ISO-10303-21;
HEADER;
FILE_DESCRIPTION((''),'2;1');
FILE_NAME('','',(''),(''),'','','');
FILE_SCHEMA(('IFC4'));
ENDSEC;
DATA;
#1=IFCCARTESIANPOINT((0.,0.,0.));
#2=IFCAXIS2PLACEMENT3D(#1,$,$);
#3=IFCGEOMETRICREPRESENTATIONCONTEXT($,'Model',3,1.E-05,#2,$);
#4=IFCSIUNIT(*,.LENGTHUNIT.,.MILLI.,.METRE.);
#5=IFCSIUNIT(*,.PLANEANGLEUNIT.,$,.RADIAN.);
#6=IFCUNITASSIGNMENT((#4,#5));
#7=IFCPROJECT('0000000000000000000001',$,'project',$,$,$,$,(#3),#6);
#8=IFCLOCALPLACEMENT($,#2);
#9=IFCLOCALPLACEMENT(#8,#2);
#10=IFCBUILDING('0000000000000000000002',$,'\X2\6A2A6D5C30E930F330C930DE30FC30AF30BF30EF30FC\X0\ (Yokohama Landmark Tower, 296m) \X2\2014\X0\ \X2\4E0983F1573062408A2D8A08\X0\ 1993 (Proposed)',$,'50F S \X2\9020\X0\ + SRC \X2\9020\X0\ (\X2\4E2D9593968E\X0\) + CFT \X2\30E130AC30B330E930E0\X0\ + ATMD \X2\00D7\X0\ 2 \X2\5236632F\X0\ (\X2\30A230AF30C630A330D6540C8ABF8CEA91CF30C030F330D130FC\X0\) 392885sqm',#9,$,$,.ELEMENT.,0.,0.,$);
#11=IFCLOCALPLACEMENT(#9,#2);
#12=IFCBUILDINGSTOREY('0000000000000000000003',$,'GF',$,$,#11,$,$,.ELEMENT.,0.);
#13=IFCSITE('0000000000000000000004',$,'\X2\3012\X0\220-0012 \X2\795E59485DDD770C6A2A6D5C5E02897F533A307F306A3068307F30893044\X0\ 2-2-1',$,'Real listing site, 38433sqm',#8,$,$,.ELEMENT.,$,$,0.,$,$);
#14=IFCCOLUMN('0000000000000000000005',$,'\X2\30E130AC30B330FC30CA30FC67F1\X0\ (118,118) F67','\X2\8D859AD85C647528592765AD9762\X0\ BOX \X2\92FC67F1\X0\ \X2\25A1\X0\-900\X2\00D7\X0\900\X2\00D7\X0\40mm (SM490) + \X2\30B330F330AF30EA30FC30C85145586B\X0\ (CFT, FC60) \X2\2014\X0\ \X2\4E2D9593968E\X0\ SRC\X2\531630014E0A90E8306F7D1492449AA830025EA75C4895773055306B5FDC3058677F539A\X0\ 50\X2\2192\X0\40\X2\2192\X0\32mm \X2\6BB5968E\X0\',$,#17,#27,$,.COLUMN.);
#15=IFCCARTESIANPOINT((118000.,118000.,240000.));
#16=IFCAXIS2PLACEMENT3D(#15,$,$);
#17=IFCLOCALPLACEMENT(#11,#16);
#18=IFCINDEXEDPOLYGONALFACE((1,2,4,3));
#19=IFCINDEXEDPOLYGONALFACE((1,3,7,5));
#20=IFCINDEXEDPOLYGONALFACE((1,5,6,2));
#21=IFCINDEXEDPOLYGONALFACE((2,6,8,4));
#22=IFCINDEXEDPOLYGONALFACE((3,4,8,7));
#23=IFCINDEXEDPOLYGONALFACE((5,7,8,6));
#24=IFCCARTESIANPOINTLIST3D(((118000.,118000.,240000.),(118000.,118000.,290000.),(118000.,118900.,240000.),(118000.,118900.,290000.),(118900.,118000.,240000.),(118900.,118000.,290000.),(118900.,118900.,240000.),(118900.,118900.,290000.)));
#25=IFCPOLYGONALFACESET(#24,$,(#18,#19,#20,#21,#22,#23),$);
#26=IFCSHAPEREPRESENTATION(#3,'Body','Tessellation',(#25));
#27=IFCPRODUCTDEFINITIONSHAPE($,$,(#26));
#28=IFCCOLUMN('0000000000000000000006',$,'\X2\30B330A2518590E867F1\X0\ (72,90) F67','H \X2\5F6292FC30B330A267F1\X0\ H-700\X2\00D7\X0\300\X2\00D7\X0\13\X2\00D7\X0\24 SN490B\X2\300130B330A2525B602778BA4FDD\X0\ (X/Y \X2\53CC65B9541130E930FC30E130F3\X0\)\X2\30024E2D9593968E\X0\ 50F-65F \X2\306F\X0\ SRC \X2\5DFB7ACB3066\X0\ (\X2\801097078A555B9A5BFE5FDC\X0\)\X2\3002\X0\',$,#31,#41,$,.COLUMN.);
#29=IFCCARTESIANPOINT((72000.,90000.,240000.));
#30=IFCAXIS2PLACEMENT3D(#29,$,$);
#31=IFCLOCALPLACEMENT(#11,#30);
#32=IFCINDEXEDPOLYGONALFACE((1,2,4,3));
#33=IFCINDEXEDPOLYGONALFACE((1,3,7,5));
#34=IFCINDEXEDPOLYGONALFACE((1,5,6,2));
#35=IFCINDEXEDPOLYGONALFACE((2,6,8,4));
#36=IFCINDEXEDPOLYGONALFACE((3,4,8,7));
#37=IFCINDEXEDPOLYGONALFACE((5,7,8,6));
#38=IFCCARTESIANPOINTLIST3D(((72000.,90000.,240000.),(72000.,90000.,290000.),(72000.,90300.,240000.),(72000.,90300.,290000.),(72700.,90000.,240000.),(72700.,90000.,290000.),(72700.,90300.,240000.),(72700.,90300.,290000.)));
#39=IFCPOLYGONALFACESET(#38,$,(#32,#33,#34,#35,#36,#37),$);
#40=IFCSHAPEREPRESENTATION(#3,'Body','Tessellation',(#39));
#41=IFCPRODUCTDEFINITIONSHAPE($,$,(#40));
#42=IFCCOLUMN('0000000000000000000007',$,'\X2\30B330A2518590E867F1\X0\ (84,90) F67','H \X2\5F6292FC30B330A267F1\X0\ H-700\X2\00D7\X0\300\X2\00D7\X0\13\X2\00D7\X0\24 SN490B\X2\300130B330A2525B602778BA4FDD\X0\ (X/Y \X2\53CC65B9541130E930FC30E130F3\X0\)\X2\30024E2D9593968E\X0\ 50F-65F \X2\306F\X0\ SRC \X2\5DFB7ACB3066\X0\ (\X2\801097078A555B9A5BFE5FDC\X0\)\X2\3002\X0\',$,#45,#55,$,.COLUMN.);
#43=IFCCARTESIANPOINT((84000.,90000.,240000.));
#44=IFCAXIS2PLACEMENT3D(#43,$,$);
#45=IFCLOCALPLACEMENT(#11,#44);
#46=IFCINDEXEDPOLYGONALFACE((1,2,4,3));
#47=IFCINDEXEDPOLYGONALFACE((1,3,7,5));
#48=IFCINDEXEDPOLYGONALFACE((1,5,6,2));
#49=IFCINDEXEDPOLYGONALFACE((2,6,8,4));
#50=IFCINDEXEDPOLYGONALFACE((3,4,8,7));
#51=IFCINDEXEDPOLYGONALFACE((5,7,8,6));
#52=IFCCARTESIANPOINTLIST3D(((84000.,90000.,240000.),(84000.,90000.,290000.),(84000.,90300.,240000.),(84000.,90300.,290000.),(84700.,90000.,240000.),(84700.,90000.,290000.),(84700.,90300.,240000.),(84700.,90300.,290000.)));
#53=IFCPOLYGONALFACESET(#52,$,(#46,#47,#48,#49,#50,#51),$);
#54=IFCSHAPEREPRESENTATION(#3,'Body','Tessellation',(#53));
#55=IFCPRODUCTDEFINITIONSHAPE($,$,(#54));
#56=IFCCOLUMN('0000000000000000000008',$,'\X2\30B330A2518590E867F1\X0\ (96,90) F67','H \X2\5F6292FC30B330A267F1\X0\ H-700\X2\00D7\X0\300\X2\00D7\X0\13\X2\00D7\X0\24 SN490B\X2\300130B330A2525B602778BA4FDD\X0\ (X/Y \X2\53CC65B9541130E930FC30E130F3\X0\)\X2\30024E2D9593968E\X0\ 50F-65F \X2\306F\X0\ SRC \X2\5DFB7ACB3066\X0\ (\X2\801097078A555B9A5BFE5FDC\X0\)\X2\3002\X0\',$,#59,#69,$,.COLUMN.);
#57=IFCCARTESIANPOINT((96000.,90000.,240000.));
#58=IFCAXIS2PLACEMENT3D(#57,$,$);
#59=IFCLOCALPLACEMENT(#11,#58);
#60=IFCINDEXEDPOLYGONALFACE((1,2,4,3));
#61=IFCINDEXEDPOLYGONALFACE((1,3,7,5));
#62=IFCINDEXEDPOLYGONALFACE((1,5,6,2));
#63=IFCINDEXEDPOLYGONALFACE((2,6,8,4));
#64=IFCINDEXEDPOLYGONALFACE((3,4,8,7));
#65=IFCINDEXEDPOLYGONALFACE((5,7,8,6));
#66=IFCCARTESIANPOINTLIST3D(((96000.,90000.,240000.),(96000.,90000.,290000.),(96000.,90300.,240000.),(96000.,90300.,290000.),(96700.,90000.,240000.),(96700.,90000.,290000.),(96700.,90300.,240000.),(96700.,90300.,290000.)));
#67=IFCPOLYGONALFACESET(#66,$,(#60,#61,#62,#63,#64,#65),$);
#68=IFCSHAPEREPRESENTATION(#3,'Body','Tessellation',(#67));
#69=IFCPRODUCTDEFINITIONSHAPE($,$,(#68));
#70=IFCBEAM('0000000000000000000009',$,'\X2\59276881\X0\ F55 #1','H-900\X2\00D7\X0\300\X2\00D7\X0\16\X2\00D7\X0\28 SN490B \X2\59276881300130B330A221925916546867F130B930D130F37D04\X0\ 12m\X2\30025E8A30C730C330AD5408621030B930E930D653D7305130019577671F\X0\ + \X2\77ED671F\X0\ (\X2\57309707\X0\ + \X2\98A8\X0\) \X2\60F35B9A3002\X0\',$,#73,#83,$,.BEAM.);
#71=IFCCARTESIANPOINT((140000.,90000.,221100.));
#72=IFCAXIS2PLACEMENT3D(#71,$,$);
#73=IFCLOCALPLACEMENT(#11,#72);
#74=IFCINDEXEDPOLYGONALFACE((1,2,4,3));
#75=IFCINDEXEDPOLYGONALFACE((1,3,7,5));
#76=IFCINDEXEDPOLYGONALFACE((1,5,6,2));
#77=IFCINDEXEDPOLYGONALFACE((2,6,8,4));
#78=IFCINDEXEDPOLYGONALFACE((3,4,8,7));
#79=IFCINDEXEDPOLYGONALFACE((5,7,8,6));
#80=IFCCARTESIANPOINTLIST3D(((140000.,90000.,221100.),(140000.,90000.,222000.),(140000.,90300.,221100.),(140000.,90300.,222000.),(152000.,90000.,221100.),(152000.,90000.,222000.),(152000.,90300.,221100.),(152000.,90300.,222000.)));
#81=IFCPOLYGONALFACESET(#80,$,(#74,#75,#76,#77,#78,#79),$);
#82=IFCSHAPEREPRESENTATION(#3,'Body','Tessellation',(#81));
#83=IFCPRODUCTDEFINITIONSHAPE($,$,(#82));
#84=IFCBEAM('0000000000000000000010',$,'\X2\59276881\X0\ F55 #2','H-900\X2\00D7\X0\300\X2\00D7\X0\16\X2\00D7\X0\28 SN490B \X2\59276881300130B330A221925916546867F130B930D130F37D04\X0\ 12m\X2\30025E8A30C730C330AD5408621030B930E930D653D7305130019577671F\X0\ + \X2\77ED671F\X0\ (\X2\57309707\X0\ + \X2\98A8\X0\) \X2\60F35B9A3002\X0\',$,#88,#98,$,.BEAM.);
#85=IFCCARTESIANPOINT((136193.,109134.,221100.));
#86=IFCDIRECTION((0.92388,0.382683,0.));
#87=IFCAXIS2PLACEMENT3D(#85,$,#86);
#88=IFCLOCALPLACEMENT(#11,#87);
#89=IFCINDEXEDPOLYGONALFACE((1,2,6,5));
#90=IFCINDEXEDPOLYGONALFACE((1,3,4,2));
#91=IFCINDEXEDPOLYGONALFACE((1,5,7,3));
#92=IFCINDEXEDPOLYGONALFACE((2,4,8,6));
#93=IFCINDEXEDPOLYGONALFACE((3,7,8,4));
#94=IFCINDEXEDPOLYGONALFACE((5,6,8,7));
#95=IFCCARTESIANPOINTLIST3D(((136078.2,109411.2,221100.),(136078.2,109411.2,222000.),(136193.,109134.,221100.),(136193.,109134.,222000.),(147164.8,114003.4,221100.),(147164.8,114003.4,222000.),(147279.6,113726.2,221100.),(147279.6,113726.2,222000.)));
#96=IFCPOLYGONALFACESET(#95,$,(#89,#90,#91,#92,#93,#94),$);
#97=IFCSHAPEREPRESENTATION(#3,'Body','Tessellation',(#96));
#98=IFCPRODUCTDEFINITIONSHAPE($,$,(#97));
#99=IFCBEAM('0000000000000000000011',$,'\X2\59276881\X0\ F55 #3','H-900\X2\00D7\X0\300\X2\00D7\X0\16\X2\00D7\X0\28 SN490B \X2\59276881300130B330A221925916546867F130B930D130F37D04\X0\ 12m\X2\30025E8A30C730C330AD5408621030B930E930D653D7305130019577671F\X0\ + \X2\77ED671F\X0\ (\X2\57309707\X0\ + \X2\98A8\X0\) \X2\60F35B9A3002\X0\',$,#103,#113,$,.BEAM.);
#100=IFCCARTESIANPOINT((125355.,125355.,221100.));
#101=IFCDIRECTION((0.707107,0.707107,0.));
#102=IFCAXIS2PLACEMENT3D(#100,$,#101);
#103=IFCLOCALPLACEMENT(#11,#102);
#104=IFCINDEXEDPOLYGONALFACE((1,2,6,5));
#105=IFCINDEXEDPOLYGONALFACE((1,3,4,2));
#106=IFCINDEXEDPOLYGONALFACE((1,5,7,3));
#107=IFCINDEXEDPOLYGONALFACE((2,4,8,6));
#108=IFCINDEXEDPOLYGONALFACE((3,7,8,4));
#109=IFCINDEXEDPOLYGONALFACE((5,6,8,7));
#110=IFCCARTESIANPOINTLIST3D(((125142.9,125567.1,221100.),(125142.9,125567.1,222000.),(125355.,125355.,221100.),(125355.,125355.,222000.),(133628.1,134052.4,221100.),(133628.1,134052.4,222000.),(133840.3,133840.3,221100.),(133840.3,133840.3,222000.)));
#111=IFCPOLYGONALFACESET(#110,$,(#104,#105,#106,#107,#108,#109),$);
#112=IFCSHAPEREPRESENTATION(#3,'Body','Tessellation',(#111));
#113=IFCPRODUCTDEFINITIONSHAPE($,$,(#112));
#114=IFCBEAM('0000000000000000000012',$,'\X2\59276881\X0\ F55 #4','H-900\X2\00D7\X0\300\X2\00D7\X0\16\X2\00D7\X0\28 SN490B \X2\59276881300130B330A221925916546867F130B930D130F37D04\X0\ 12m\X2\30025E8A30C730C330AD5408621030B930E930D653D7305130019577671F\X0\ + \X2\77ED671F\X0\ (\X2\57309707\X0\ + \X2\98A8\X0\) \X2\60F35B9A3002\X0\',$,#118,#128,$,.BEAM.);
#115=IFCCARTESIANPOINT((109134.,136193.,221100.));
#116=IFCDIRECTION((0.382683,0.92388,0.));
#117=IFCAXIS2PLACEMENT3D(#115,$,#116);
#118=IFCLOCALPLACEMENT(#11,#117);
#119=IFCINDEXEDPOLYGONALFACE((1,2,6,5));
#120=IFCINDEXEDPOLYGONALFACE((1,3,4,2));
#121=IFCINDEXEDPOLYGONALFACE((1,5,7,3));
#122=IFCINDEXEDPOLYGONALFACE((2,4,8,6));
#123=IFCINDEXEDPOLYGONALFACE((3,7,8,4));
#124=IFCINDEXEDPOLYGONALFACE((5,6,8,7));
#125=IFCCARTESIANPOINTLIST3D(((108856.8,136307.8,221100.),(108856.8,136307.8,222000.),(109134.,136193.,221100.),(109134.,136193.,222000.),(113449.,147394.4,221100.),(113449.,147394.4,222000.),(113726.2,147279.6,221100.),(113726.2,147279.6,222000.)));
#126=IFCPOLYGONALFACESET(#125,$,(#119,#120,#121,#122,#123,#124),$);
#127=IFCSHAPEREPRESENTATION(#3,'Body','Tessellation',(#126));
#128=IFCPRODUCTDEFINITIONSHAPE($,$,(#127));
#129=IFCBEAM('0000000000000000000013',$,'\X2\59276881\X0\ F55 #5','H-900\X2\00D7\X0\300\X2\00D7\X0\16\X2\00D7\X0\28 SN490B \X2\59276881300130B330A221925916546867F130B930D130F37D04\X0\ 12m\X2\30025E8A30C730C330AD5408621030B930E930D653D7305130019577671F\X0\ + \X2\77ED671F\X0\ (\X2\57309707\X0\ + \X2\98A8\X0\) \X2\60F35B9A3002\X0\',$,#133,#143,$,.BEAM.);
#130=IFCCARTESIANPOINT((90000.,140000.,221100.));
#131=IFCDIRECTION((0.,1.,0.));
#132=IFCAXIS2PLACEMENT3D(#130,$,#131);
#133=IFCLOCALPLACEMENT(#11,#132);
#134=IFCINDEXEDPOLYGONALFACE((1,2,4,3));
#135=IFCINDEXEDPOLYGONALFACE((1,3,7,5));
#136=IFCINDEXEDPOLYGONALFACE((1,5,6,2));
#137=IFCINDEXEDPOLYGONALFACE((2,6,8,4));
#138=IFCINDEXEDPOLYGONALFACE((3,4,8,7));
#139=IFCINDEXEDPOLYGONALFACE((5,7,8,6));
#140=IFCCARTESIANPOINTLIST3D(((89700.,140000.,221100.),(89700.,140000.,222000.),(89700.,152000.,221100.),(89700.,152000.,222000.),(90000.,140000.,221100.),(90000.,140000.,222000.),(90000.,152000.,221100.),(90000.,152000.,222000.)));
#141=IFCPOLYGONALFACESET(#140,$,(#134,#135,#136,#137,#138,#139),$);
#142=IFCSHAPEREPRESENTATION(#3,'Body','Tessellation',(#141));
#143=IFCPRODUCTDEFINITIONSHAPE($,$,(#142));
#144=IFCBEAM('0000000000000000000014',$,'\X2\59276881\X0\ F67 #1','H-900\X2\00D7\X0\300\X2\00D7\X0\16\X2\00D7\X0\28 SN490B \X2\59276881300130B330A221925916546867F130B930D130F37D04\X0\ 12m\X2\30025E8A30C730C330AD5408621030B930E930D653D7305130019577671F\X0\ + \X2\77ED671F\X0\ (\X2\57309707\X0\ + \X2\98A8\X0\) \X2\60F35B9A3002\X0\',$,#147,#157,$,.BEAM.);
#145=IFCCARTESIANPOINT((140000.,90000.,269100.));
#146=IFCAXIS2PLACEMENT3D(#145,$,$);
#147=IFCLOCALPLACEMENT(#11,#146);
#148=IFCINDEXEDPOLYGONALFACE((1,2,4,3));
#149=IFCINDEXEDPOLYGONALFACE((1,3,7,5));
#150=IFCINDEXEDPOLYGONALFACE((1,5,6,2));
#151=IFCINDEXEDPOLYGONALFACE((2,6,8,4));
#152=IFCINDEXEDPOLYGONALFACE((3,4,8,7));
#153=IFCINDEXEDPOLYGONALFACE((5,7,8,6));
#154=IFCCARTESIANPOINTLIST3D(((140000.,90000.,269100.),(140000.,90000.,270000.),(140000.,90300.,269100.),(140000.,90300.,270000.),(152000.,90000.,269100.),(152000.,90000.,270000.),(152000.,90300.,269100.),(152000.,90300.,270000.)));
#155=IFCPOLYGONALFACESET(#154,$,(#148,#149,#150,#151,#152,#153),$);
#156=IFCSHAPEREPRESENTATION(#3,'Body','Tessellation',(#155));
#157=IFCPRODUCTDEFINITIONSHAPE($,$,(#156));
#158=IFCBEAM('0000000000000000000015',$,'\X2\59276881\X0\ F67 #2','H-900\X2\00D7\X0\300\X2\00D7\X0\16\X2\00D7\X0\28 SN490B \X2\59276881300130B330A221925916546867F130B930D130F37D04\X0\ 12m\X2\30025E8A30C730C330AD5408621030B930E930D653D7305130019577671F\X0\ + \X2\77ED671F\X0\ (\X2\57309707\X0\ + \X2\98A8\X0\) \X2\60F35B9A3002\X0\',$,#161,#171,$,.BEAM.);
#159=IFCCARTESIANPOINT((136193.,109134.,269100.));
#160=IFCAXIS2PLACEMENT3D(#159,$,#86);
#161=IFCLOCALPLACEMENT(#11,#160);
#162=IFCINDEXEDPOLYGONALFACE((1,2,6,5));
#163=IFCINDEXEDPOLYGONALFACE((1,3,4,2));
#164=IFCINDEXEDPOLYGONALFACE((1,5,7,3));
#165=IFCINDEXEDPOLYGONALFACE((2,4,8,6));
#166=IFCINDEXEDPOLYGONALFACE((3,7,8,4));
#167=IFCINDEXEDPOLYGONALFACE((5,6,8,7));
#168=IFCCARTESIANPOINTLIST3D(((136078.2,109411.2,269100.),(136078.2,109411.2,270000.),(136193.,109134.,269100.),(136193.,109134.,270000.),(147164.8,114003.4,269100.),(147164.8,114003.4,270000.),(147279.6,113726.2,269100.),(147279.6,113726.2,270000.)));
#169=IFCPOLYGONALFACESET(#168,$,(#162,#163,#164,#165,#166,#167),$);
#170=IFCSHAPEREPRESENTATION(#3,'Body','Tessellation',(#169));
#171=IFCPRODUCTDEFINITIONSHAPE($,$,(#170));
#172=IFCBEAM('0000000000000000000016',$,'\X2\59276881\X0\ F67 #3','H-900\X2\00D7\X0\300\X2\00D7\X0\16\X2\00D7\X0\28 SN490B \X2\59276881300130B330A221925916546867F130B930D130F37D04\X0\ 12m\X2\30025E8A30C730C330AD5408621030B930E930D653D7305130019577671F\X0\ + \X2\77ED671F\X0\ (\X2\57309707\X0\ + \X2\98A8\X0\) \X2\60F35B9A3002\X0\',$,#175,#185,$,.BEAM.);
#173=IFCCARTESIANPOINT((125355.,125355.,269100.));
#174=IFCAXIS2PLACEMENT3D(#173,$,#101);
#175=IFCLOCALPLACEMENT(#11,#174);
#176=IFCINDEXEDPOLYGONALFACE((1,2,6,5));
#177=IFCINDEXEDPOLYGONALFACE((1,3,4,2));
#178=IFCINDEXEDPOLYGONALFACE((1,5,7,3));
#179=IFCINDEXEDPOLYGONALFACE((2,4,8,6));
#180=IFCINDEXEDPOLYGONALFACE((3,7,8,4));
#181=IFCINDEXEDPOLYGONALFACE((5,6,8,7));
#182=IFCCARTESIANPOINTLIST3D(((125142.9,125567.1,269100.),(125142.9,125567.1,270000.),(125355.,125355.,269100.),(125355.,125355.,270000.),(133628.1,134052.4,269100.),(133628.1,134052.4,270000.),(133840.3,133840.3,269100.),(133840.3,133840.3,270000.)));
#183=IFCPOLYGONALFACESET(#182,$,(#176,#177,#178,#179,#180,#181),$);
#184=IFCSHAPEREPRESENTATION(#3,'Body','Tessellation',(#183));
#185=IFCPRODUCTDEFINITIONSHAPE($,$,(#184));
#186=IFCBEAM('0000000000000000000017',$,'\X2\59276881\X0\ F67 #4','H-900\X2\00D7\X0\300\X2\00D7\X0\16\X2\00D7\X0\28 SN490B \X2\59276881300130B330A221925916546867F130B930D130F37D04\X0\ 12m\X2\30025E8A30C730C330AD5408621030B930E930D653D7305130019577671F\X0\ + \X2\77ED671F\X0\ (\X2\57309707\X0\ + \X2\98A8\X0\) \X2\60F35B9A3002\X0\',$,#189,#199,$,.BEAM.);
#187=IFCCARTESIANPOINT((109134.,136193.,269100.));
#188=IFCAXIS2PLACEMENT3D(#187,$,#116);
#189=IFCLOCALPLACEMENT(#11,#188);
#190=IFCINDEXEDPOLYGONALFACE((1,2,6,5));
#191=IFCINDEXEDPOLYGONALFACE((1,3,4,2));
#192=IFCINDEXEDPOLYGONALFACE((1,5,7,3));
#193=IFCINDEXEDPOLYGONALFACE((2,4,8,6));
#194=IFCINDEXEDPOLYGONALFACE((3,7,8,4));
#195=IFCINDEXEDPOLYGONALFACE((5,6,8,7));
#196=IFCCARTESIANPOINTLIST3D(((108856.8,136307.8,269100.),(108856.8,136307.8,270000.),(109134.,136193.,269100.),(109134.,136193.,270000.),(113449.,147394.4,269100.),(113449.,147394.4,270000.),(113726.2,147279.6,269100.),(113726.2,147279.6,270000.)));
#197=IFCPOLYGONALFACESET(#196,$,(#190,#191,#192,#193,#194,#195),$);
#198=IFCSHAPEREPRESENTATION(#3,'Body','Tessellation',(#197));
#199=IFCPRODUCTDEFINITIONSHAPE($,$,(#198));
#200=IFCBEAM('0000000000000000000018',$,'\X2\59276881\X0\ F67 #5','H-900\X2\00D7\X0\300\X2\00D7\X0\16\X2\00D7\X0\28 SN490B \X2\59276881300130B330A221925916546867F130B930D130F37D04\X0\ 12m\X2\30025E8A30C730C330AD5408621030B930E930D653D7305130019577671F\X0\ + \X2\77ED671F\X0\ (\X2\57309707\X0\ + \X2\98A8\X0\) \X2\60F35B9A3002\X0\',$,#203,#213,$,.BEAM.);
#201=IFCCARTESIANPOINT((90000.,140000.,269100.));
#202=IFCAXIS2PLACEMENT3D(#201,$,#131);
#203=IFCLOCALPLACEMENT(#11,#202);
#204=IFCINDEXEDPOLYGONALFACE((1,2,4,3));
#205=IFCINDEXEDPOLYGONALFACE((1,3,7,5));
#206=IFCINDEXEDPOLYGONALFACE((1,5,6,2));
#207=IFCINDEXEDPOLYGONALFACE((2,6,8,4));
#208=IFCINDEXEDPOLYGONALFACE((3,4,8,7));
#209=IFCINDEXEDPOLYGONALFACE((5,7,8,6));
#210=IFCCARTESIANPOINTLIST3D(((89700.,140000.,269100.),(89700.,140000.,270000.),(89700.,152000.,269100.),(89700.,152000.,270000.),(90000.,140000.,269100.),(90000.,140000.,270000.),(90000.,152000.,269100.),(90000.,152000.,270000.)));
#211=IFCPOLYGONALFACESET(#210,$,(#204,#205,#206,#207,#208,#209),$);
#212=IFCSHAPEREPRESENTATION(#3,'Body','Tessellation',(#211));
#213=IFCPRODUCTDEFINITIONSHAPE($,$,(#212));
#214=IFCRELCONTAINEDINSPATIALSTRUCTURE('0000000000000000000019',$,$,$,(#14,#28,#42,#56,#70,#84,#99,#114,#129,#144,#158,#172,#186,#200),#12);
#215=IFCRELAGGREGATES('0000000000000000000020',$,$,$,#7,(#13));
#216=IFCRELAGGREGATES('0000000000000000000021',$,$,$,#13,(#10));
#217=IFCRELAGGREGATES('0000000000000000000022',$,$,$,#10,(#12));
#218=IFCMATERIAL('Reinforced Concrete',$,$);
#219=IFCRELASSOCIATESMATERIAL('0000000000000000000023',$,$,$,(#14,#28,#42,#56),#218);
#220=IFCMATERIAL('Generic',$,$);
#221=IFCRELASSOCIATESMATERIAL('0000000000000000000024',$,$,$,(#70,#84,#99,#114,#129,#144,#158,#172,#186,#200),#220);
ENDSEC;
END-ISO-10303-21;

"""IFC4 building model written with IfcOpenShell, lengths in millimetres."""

from ifc_helpers import new_model, si_unit, frame, frame_2d, origin, place, context, project, spatial, rectangle, extrude, material, element, save


model = new_model("IFC4")

# Units and contexts
model_context = context("Model", 3, precision=1e-05, world=origin())
ifc_project = project(units=[si_unit("LENGTHUNIT", "METRE", prefix="MILLI"), si_unit("PLANEANGLEUNIT", "RADIAN")], contexts=[model_context])

# Site, building, storey
site_placement = place(None, origin())
site = spatial("IfcSite", under=ifc_project, at=site_placement, Name="〒220-0012 神奈川県横浜市西区みなとみらい 2-2-1", ObjectType="Real listing site, 38433sqm", CompositionType="ELEMENT", RefElevation=0.0)
building_placement = place(site_placement, origin())
building = spatial("IfcBuilding", under=site, at=building_placement, Name="横浜ランドマークタワー (Yokohama Landmark Tower, 296m) — 三菱地所設計 1993 (Proposed)", ObjectType="50F S 造 + SRC 造 (中間階) + CFT メガコラム + ATMD × 2 制振 (アクティブ同調質量ダンパー) 392885sqm", CompositionType="ELEMENT", ElevationOfRefHeight=0.0, ElevationOfTerrain=0.0)
storey_placement = place(building_placement, origin())
storey = spatial("IfcBuildingStorey", under=building, at=storey_placement, Name="GF", CompositionType="ELEMENT", Elevation=0.0)

# Columns
ifc_material_1 = material(Name="Reinforced Concrete")
column_1_placement = place(storey_placement, frame((118000.0, 118000.0, 240000.0)))
element("IfcColumn", 1, at=column_1_placement, inside=storey, material=ifc_material_1, Name="メガコーナー柱 (118,118) F67", Description="超高層用大断面 BOX 鋼柱 □-900×900×40mm (SM490) + コンクリート充填 (CFT, FC60) — 中間階 SRC化、上部は純鉄骨。座屈長さに応じ板厚 50→40→32mm 段階", PredefinedType="COLUMN", context=model_context, shape_type="SweptSolid", body=[
    extrude(rectangle(XDim=900.0, YDim=900.0, at=frame_2d((450.0, 450.0))), frame((118000.0, 118000.0, 240000.0)), (0.0, 0.0, 1.0), 50000.0),
])
column_2_placement = place(storey_placement, frame((72000.0, 90000.0, 240000.0)))
element("IfcColumn", 2, at=column_2_placement, inside=storey, material=ifc_material_1, Name="コア内部柱 (72,90) F67", Description="H 形鋼コア柱 H-700×300×13×24 SN490B、コア剛性確保 (X/Y 双方向ラーメン)。中間階 50F-65F は SRC 巻立て (耐震評定対応)。", PredefinedType="COLUMN", context=model_context, shape_type="SweptSolid", body=[
    extrude(rectangle(XDim=700.0, YDim=300.0, at=frame_2d((350.0, 150.0))), frame((72000.0, 90000.0, 240000.0)), (0.0, 0.0, 1.0), 50000.0),
])
column_3_placement = place(storey_placement, frame((84000.0, 90000.0, 240000.0)))
element("IfcColumn", 3, at=column_3_placement, inside=storey, material=ifc_material_1, Name="コア内部柱 (84,90) F67", Description="H 形鋼コア柱 H-700×300×13×24 SN490B、コア剛性確保 (X/Y 双方向ラーメン)。中間階 50F-65F は SRC 巻立て (耐震評定対応)。", PredefinedType="COLUMN", context=model_context, shape_type="SweptSolid", body=[
    extrude(rectangle(XDim=700.0, YDim=300.0, at=frame_2d((350.0, 150.0))), frame((84000.0, 90000.0, 240000.0)), (0.0, 0.0, 1.0), 50000.0),
])
column_4_placement = place(storey_placement, frame((96000.0, 90000.0, 240000.0)))
element("IfcColumn", 4, at=column_4_placement, inside=storey, material=ifc_material_1, Name="コア内部柱 (96,90) F67", Description="H 形鋼コア柱 H-700×300×13×24 SN490B、コア剛性確保 (X/Y 双方向ラーメン)。中間階 50F-65F は SRC 巻立て (耐震評定対応)。", PredefinedType="COLUMN", context=model_context, shape_type="SweptSolid", body=[
    extrude(rectangle(XDim=700.0, YDim=300.0, at=frame_2d((350.0, 150.0))), frame((96000.0, 90000.0, 240000.0)), (0.0, 0.0, 1.0), 50000.0),
])

# Beams
ifc_material_2 = material(Name="Generic")
beam_1_placement = place(storey_placement, frame((140000.0, 90000.0, 221100.0)))
element("IfcBeam", 5, at=beam_1_placement, inside=storey, material=ifc_material_2, Name="大梁 F55 #1", Description="H-900×300×16×28 SN490B 大梁、コア→外周柱スパン約 12m。床デッキ合成スラブ受け、長期 + 短期 (地震 + 風) 想定。", PredefinedType="BEAM", context=model_context, shape_type="SweptSolid", body=[
    extrude(rectangle(XDim=12000.0, YDim=300.0, at=frame_2d((6000.0, 150.0))), frame((140000.0, 90000.0, 221100.0)), (0.0, 0.0, 1.0), 900.0),
])
beam_2_placement = place(storey_placement, frame((136193.0, 109134.0, 221100.0), x_axis=(0.92388, 0.382683, 0.0)))
element("IfcBeam", 6, at=beam_2_placement, inside=storey, material=ifc_material_2, Name="大梁 F55 #2", Description="H-900×300×16×28 SN490B 大梁、コア→外周柱スパン約 12m。床デッキ合成スラブ受け、長期 + 短期 (地震 + 風) 想定。", PredefinedType="BEAM", context=model_context, shape_type="SweptSolid", body=[
    extrude(rectangle(XDim=12000.0, YDim=300.0, at=frame_2d((6000.0, 150.0))), frame((136193.0, 109134.0, 221100.0), x_axis=(0.92388, 0.382683, 0.0)), (0.0, 0.0, 1.0), 900.0),
])
beam_3_placement = place(storey_placement, frame((125355.0, 125355.0, 221100.0), x_axis=(0.707107, 0.707107, 0.0)))
element("IfcBeam", 7, at=beam_3_placement, inside=storey, material=ifc_material_2, Name="大梁 F55 #3", Description="H-900×300×16×28 SN490B 大梁、コア→外周柱スパン約 12m。床デッキ合成スラブ受け、長期 + 短期 (地震 + 風) 想定。", PredefinedType="BEAM", context=model_context, shape_type="SweptSolid", body=[
    extrude(rectangle(XDim=12000.0, YDim=300.0, at=frame_2d((6000.0, 150.0))), frame((125355.0, 125355.0, 221100.0), x_axis=(0.707107, 0.707107, 0.0)), (0.0, 0.0, 1.0), 900.0),
])
beam_4_placement = place(storey_placement, frame((109134.0, 136193.0, 221100.0), x_axis=(0.382683, 0.92388, 0.0)))
element("IfcBeam", 8, at=beam_4_placement, inside=storey, material=ifc_material_2, Name="大梁 F55 #4", Description="H-900×300×16×28 SN490B 大梁、コア→外周柱スパン約 12m。床デッキ合成スラブ受け、長期 + 短期 (地震 + 風) 想定。", PredefinedType="BEAM", context=model_context, shape_type="SweptSolid", body=[
    extrude(rectangle(XDim=12000.0, YDim=300.0, at=frame_2d((6000.0, 150.0))), frame((109134.0, 136193.0, 221100.0), x_axis=(0.382683, 0.92388, 0.0)), (0.0, 0.0, 1.0), 900.0),
])
beam_5_placement = place(storey_placement, frame((90000.0, 140000.0, 221100.0), x_axis=(0.0, 1.0, 0.0)))
element("IfcBeam", 9, at=beam_5_placement, inside=storey, material=ifc_material_2, Name="大梁 F55 #5", Description="H-900×300×16×28 SN490B 大梁、コア→外周柱スパン約 12m。床デッキ合成スラブ受け、長期 + 短期 (地震 + 風) 想定。", PredefinedType="BEAM", context=model_context, shape_type="SweptSolid", body=[
    extrude(rectangle(XDim=12000.0, YDim=300.0, at=frame_2d((6000.0, 150.0))), frame((90000.0, 140000.0, 221100.0), x_axis=(0.0, 1.0, 0.0)), (0.0, 0.0, 1.0), 900.0),
])
beam_6_placement = place(storey_placement, frame((140000.0, 90000.0, 269100.0)))
element("IfcBeam", 10, at=beam_6_placement, inside=storey, material=ifc_material_2, Name="大梁 F67 #1", Description="H-900×300×16×28 SN490B 大梁、コア→外周柱スパン約 12m。床デッキ合成スラブ受け、長期 + 短期 (地震 + 風) 想定。", PredefinedType="BEAM", context=model_context, shape_type="SweptSolid", body=[
    extrude(rectangle(XDim=12000.0, YDim=300.0, at=frame_2d((6000.0, 150.0))), frame((140000.0, 90000.0, 269100.0)), (0.0, 0.0, 1.0), 900.0),
])
beam_7_placement = place(storey_placement, frame((136193.0, 109134.0, 269100.0), x_axis=(0.92388, 0.382683, 0.0)))
element("IfcBeam", 11, at=beam_7_placement, inside=storey, material=ifc_material_2, Name="大梁 F67 #2", Description="H-900×300×16×28 SN490B 大梁、コア→外周柱スパン約 12m。床デッキ合成スラブ受け、長期 + 短期 (地震 + 風) 想定。", PredefinedType="BEAM", context=model_context, shape_type="SweptSolid", body=[
    extrude(rectangle(XDim=12000.0, YDim=300.0, at=frame_2d((6000.0, 150.0))), frame((136193.0, 109134.0, 269100.0), x_axis=(0.92388, 0.382683, 0.0)), (0.0, 0.0, 1.0), 900.0),
])
beam_8_placement = place(storey_placement, frame((125355.0, 125355.0, 269100.0), x_axis=(0.707107, 0.707107, 0.0)))
element("IfcBeam", 12, at=beam_8_placement, inside=storey, material=ifc_material_2, Name="大梁 F67 #3", Description="H-900×300×16×28 SN490B 大梁、コア→外周柱スパン約 12m。床デッキ合成スラブ受け、長期 + 短期 (地震 + 風) 想定。", PredefinedType="BEAM", context=model_context, shape_type="SweptSolid", body=[
    extrude(rectangle(XDim=12000.0, YDim=300.0, at=frame_2d((6000.0, 150.0))), frame((125355.0, 125355.0, 269100.0), x_axis=(0.707107, 0.707107, 0.0)), (0.0, 0.0, 1.0), 900.0),
])
beam_9_placement = place(storey_placement, frame((109134.0, 136193.0, 269100.0), x_axis=(0.382683, 0.92388, 0.0)))
element("IfcBeam", 13, at=beam_9_placement, inside=storey, material=ifc_material_2, Name="大梁 F67 #4", Description="H-900×300×16×28 SN490B 大梁、コア→外周柱スパン約 12m。床デッキ合成スラブ受け、長期 + 短期 (地震 + 風) 想定。", PredefinedType="BEAM", context=model_context, shape_type="SweptSolid", body=[
    extrude(rectangle(XDim=12000.0, YDim=300.0, at=frame_2d((6000.0, 150.0))), frame((109134.0, 136193.0, 269100.0), x_axis=(0.382683, 0.92388, 0.0)), (0.0, 0.0, 1.0), 900.0),
])
beam_10_placement = place(storey_placement, frame((90000.0, 140000.0, 269100.0), x_axis=(0.0, 1.0, 0.0)))
element("IfcBeam", 14, at=beam_10_placement, inside=storey, material=ifc_material_2, Name="大梁 F67 #5", Description="H-900×300×16×28 SN490B 大梁、コア→外周柱スパン約 12m。床デッキ合成スラブ受け、長期 + 短期 (地震 + 風) 想定。", PredefinedType="BEAM", context=model_context, shape_type="SweptSolid", body=[
    extrude(rectangle(XDim=12000.0, YDim=300.0, at=frame_2d((6000.0, 150.0))), frame((90000.0, 140000.0, 269100.0), x_axis=(0.0, 1.0, 0.0)), (0.0, 0.0, 1.0), 900.0),
])

save(model, "model.ifc")
